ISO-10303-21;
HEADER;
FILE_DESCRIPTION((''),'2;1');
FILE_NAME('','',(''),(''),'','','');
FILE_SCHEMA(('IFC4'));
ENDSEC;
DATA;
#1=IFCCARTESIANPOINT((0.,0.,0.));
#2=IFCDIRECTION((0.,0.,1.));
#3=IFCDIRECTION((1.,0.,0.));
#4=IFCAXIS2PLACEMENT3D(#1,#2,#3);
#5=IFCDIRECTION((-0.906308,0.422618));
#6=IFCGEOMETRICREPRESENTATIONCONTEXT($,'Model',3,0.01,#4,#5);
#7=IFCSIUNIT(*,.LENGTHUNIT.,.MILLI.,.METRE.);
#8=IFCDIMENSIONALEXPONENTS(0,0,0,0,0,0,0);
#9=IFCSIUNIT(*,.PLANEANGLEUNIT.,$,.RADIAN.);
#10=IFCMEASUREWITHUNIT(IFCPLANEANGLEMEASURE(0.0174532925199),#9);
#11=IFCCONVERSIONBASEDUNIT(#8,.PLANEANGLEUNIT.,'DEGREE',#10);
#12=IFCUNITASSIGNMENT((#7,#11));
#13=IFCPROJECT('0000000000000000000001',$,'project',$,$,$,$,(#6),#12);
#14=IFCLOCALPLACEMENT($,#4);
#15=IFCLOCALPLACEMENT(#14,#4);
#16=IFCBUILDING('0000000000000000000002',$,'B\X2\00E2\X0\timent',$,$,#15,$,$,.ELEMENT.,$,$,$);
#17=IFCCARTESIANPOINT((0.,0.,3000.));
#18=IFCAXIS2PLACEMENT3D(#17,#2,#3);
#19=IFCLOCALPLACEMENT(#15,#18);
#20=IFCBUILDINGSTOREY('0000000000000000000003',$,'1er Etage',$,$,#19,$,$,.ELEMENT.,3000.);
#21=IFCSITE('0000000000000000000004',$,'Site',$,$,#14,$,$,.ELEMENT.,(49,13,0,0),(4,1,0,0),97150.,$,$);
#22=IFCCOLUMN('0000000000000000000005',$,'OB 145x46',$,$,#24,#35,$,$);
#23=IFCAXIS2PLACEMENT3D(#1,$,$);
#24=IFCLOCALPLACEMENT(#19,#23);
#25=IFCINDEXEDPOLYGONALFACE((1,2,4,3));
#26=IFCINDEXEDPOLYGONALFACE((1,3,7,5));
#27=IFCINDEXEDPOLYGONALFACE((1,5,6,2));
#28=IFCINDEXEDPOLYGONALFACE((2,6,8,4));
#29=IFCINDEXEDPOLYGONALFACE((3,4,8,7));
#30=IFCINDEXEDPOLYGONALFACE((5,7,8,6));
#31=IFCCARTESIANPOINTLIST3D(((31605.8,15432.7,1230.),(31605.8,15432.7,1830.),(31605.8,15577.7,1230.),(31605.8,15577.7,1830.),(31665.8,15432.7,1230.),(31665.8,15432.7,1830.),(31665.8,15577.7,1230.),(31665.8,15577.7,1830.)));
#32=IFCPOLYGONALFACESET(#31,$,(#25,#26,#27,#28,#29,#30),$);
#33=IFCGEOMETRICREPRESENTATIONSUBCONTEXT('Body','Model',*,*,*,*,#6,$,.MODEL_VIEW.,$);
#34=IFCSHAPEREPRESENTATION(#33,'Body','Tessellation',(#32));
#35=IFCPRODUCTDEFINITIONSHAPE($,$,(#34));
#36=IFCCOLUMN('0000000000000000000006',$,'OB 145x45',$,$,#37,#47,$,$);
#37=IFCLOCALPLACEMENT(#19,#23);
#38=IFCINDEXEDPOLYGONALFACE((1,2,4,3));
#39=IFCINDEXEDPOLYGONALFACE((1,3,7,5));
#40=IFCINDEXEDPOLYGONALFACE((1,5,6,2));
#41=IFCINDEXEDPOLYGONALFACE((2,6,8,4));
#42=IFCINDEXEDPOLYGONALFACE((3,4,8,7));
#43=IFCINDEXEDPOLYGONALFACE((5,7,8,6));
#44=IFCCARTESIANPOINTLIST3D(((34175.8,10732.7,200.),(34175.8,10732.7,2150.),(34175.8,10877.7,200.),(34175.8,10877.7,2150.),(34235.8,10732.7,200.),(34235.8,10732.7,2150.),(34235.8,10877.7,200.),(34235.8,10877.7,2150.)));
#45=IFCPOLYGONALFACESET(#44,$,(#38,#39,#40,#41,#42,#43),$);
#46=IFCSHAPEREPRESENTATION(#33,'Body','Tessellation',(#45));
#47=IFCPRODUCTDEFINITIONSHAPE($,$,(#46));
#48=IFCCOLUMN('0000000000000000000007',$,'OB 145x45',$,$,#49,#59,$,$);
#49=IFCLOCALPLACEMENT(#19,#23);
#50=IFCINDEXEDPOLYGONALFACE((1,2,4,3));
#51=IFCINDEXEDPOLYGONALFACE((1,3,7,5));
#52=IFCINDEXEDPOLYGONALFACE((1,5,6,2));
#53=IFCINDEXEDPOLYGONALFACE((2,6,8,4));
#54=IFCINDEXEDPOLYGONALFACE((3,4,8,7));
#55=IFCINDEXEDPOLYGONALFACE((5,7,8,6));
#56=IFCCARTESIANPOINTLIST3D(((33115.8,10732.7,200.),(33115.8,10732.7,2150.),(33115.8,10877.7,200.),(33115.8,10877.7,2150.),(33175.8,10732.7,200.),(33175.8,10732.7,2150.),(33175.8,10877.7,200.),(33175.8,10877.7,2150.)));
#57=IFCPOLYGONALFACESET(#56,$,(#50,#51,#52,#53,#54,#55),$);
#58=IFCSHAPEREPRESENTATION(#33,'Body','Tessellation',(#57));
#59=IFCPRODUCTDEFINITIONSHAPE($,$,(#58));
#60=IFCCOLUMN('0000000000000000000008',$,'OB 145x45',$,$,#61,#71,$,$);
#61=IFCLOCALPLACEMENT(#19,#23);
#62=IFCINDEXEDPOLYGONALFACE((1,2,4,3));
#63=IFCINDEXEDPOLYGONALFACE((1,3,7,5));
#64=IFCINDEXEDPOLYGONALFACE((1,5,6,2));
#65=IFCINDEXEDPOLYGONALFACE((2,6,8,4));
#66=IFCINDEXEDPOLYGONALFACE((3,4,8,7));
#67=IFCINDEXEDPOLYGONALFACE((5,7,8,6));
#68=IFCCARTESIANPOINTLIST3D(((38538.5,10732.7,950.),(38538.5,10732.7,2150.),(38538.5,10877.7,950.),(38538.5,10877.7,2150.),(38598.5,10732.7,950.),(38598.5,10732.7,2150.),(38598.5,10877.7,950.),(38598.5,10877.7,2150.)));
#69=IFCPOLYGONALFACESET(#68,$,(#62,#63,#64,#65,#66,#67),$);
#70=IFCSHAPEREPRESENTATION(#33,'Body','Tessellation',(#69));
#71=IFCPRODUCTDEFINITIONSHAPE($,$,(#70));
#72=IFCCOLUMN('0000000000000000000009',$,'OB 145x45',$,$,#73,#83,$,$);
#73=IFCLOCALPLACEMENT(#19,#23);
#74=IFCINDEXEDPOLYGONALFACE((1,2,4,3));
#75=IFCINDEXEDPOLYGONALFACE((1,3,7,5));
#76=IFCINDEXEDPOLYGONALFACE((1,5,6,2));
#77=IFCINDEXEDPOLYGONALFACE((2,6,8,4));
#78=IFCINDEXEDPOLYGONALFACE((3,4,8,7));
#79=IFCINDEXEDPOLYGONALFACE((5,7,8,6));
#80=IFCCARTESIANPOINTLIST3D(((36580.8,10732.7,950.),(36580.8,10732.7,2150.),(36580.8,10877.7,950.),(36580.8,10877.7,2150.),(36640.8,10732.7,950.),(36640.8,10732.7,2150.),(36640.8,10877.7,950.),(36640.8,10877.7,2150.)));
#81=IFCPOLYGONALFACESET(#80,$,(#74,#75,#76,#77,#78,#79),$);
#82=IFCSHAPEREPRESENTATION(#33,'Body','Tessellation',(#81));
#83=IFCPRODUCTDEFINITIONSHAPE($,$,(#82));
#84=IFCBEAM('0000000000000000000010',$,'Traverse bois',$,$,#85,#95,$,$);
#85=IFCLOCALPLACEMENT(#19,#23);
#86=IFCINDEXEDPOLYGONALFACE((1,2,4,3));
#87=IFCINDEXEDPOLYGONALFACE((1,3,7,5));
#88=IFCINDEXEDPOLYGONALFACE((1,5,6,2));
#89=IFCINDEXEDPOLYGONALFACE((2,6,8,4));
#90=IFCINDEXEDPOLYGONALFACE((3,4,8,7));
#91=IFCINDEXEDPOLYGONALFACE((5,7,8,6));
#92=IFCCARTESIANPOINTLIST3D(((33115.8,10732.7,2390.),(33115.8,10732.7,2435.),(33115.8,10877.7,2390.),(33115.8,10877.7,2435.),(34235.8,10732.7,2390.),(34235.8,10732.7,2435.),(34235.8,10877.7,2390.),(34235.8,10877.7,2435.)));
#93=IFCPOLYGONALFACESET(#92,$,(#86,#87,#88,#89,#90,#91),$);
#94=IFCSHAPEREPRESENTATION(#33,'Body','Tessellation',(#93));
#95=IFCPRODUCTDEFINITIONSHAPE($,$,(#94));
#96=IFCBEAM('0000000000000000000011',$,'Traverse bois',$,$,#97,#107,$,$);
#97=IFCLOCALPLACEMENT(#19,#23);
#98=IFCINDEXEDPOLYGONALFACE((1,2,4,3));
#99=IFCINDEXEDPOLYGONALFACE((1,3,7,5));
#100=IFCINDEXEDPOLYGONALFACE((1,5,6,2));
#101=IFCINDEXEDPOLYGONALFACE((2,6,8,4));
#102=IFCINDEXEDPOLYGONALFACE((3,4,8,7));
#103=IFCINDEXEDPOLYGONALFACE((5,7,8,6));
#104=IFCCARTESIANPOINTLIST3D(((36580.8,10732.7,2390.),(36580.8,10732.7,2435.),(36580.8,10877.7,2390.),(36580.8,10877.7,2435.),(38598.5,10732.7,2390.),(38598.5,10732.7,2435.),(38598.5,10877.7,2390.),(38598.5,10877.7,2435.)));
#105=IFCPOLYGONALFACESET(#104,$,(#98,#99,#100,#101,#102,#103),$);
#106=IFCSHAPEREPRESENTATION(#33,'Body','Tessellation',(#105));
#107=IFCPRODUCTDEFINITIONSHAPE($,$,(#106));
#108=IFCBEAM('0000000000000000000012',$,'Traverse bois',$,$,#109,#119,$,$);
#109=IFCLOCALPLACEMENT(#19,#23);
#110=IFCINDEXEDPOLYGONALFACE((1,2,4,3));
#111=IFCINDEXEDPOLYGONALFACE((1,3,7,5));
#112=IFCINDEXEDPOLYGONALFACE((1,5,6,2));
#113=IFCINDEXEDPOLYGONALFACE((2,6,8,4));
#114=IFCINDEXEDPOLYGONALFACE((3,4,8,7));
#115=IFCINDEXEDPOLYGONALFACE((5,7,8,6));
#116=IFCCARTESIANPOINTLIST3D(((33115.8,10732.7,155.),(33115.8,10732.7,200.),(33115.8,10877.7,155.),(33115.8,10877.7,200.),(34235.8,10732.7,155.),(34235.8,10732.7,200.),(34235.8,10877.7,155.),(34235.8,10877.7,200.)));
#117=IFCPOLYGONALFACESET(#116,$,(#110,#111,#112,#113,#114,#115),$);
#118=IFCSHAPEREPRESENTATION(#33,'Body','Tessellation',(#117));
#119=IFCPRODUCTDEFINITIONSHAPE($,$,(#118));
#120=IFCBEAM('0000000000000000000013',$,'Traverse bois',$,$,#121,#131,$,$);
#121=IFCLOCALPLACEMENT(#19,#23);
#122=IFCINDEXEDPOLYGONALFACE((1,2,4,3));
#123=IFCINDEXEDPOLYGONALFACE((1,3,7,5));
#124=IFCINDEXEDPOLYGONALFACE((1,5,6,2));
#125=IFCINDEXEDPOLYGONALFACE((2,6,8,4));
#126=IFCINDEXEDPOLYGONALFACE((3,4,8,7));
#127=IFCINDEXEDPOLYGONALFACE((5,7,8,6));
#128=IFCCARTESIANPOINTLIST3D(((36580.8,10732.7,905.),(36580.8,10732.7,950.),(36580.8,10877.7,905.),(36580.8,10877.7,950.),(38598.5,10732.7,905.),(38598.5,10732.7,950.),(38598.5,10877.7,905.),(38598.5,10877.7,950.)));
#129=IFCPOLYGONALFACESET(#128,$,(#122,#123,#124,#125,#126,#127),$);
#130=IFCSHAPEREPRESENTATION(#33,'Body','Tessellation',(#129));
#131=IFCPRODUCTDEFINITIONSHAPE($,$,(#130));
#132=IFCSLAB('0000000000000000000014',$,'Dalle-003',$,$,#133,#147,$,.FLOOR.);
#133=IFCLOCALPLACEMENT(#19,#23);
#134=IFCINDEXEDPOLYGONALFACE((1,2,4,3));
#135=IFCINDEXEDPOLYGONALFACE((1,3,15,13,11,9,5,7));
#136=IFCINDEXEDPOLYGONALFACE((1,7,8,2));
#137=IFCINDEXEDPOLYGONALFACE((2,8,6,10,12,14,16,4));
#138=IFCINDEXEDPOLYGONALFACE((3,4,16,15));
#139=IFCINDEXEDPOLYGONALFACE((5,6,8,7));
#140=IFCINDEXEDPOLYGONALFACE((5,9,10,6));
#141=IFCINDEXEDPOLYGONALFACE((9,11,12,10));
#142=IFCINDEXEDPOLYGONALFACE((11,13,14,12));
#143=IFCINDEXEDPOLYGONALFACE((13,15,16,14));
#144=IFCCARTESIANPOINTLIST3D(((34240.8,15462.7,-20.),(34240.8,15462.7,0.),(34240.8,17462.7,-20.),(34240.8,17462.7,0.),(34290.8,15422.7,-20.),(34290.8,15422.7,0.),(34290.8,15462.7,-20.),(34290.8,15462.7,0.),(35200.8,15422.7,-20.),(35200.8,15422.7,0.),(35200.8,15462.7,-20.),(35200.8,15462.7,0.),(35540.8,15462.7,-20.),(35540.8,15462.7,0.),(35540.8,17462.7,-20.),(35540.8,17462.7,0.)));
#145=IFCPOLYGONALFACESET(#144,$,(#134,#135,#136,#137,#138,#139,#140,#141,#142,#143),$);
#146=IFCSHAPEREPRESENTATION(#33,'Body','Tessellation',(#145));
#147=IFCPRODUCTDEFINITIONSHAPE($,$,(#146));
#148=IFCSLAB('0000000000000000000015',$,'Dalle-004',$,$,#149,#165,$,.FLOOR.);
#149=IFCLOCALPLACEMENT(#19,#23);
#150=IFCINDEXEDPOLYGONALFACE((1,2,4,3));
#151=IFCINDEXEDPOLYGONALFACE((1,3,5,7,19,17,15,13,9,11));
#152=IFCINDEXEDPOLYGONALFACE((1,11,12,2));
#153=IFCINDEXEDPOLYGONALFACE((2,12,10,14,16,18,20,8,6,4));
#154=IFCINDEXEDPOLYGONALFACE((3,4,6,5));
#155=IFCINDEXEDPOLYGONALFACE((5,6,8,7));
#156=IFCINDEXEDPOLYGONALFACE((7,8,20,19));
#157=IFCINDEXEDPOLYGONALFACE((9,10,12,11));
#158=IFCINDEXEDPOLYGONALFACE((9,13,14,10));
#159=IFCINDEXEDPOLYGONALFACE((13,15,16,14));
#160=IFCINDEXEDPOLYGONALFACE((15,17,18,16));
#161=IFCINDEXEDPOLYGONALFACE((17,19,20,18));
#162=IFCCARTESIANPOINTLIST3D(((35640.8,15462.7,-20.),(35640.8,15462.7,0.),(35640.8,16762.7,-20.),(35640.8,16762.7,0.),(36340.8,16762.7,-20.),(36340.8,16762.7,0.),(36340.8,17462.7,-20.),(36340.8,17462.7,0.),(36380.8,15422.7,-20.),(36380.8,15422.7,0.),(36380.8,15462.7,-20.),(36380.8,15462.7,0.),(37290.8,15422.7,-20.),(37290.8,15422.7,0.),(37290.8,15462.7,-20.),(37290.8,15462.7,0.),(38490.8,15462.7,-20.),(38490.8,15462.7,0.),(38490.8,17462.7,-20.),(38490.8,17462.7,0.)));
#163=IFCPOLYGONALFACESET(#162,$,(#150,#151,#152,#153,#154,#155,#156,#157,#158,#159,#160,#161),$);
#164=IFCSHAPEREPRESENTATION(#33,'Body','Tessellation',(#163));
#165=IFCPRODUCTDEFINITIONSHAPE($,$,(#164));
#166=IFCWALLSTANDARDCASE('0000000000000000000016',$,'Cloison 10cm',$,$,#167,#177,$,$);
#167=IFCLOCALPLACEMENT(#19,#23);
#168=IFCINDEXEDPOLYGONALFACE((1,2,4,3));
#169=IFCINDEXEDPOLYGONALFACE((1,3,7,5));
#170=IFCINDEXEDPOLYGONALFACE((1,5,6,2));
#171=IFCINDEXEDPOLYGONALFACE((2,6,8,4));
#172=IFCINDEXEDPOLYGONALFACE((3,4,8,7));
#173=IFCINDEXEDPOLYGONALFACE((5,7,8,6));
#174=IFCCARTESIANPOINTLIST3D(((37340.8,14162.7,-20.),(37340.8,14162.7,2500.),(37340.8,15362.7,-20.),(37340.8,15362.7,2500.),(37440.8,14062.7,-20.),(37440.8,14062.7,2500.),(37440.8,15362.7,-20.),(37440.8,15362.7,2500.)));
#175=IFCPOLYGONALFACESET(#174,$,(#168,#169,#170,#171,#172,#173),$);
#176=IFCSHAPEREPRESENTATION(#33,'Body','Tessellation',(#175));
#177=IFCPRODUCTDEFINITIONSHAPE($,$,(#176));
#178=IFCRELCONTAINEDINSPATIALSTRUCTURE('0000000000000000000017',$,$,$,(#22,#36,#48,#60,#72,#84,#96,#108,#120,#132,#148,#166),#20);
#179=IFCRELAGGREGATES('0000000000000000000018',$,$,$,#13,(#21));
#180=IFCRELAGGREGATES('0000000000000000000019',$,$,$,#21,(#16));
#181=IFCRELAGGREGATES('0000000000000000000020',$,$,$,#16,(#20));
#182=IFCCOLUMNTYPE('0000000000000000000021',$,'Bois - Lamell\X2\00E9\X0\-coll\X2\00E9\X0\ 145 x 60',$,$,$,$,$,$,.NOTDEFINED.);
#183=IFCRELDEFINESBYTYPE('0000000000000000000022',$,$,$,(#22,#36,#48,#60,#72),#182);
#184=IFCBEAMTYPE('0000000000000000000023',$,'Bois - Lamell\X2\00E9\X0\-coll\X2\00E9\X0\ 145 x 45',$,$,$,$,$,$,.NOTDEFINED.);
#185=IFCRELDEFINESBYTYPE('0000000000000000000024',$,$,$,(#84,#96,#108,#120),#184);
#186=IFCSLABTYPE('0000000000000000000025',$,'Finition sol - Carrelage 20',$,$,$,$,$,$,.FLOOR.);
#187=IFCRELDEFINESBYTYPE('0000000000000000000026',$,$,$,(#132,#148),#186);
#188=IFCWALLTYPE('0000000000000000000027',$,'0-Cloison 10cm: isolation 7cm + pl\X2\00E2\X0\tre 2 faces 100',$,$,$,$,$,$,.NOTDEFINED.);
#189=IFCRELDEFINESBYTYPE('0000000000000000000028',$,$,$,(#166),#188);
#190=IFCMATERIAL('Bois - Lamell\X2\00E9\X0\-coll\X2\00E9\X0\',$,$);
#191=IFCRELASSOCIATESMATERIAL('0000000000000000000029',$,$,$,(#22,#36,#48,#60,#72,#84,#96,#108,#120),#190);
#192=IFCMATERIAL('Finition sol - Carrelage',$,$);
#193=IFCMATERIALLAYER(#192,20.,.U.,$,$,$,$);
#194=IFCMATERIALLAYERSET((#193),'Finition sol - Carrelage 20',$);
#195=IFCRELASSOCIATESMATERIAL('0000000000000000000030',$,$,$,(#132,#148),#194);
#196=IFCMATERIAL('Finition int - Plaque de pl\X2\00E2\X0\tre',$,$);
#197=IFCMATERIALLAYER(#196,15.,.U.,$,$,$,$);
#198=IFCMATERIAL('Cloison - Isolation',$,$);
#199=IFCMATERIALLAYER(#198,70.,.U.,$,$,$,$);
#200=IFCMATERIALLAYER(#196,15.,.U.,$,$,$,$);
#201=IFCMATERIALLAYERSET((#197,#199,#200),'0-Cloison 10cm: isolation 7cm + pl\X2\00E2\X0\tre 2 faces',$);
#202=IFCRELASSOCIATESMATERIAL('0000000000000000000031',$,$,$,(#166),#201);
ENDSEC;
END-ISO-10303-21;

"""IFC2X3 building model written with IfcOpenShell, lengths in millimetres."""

from ifc_helpers import new_model, entity, si_unit, converted_unit, direction, frame, frame_2d, origin_with_axes, origin_2d_with_axis, place, context, subcontext, project, spatial, polyline, rectangle, outline, extrude, material, layer, layer_set, layer_usage, type_object, element, save


model = new_model("IFC2X3")

# Units and contexts
model_context = context("Model", 3, precision=0.01, world=origin_with_axes(), true_north=direction((-0.906308, 0.422618)))
body_context = subcontext(model_context, "Body", "Model", "MODEL_VIEW")
ifc_project = project(units=[si_unit("LENGTHUNIT", "METRE", prefix="MILLI"), converted_unit("PLANEANGLEUNIT", "DEGREE", entity("IfcPlaneAngleMeasure", 0.0174532925199), si_unit("PLANEANGLEUNIT", "RADIAN"), dimensions=[0, 0, 0, 0, 0, 0, 0])], contexts=[model_context])

# Site, building, storey
site_placement = place(None, origin_with_axes())
site = spatial("IfcSite", under=ifc_project, at=site_placement, Name="Site", CompositionType="ELEMENT", RefLatitude=(49, 13, 0, 0), RefLongitude=(4, 1, 0, 0), RefElevation=97150.0)
building_placement = place(site_placement, origin_with_axes())
building = spatial("IfcBuilding", under=site, at=building_placement, Name="Bâtiment", CompositionType="ELEMENT")
storey_placement = place(building_placement, frame((0.0, 0.0, 3000.0), z_axis=(0.0, 0.0, 1.0), x_axis=(1.0, 0.0, 0.0)))
storey = spatial("IfcBuildingStorey", under=building, at=storey_placement, Name="1er Etage", CompositionType="ELEMENT", Elevation=3000.0)

# Columns
ifc_material_1 = material(Name="Bois - Lamellé-collé")
column_type = type_object("IfcColumnType", Name="Bois - Lamellé-collé 145 x 60", PredefinedType="NOTDEFINED")
column_placement = place(storey_placement, frame((31635.8, 15505.2, 1230.0), z_axis=(0.0, 0.0, 1.0), x_axis=(0.0, -1.0, 0.0)))
element("IfcColumn", 1, at=column_placement, inside=storey, type_object=column_type, material=ifc_material_1, Name="OB 145x46", context=body_context, shape_type="SweptSolid", body=[
    extrude(rectangle(XDim=145.0, YDim=60.0, at=origin_2d_with_axis()), origin_with_axes(), (0.0, 0.0, 1.0), 600.0),
])
for number, where, z_axis, x_axis, name in (
    (2, (34205.8, 10805.2, 200.0), (0.0, 0.0, 1.0), (0.0, 1.0, 0.0), "OB 145x45"),
    (3, (33145.8, 10805.2, 200.0), (0.0, 0.0, 1.0), (0.0, 1.0, 0.0), "OB 145x45"),
):
    element("IfcColumn", number, at=place(storey_placement, frame(where, z_axis=z_axis, x_axis=x_axis)), inside=storey, type_object=column_type, material=ifc_material_1, Name=name, context=body_context, shape_type="SweptSolid", body=[
        extrude(rectangle(XDim=145.0, YDim=60.0, at=origin_2d_with_axis()), frame((0.0, 0.0, 0.0), z_axis=(0.0, 0.0, -1.0), x_axis=(-1.0, 0.0, 0.0)), (0.0, 0.0, -1.0), 1950.0),
    ])
for number, where, z_axis, x_axis, name in (
    (4, (38568.5, 10805.2, 950.0), (0.0, 0.0, 1.0), (0.0, 1.0, 0.0), "OB 145x45"),
    (5, (36610.8, 10805.2, 950.0), (0.0, 0.0, 1.0), (0.0, 1.0, 0.0), "OB 145x45"),
):
    element("IfcColumn", number, at=place(storey_placement, frame(where, z_axis=z_axis, x_axis=x_axis)), inside=storey, type_object=column_type, material=ifc_material_1, Name=name, context=body_context, shape_type="SweptSolid", body=[
        extrude(rectangle(XDim=145.0, YDim=60.0, at=origin_2d_with_axis()), frame((0.0, 0.0, 0.0), z_axis=(0.0, 0.0, -1.0), x_axis=(-1.0, 0.0, 0.0)), (0.0, 0.0, -1.0), 1200.0),
    ])

# Beams
beam_type = type_object("IfcBeamType", Name="Bois - Lamellé-collé 145 x 45", PredefinedType="NOTDEFINED")
beam_1_placement = place(storey_placement, frame((33115.8, 10805.2, 2435.0), z_axis=(0.0, 0.0, 1.0), x_axis=(0.0, -1.0, 0.0)))
element("IfcBeam", 6, at=beam_1_placement, inside=storey, type_object=beam_type, material=ifc_material_1, Name="Traverse bois", context=body_context, shape_type="SweptSolid", body=[
    extrude(rectangle(XDim=45.0, YDim=145.0, at=frame_2d((-22.5, 0.0), x_axis=(1.0, 0.0))), frame((0.0, 0.0, 0.0), z_axis=(0.0, 1.0, 0.0), x_axis=(0.0, 0.0, 1.0)), (0.0, 0.0, 1.0), 1120.0),
])
beam_2_placement = place(storey_placement, frame((36580.8, 10805.2, 2435.0), z_axis=(0.0, 0.0, 1.0), x_axis=(0.0, -1.0, 0.0)))
element("IfcBeam", 7, at=beam_2_placement, inside=storey, type_object=beam_type, material=ifc_material_1, Name="Traverse bois", context=body_context, shape_type="SweptSolid", body=[
    extrude(rectangle(XDim=45.0, YDim=145.0, at=frame_2d((-22.5, 0.0), x_axis=(1.0, 0.0))), frame((0.0, 0.0, 0.0), z_axis=(0.0, 1.0, 0.0), x_axis=(0.0, 0.0, 1.0)), (0.0, 0.0, 1.0), 2017.7),
])
beam_3_placement = place(storey_placement, frame((33115.8, 10805.2, 200.0), z_axis=(0.0, 0.0, 1.0), x_axis=(0.0, -1.0, 0.0)))
element("IfcBeam", 8, at=beam_3_placement, inside=storey, type_object=beam_type, material=ifc_material_1, Name="Traverse bois", context=body_context, shape_type="SweptSolid", body=[
    extrude(rectangle(XDim=45.0, YDim=145.0, at=frame_2d((-22.5, 0.0), x_axis=(1.0, 0.0))), frame((0.0, 0.0, 0.0), z_axis=(0.0, 1.0, 0.0), x_axis=(0.0, 0.0, 1.0)), (0.0, 0.0, 1.0), 1120.0),
])
beam_4_placement = place(storey_placement, frame((36580.8, 10805.2, 950.0), z_axis=(0.0, 0.0, 1.0), x_axis=(0.0, -1.0, 0.0)))
element("IfcBeam", 9, at=beam_4_placement, inside=storey, type_object=beam_type, material=ifc_material_1, Name="Traverse bois", context=body_context, shape_type="SweptSolid", body=[
    extrude(rectangle(XDim=45.0, YDim=145.0, at=frame_2d((-22.5, 0.0), x_axis=(1.0, 0.0))), frame((0.0, 0.0, 0.0), z_axis=(0.0, 1.0, 0.0), x_axis=(0.0, 0.0, 1.0)), (0.0, 0.0, 1.0), 2017.7),
])

# Slabs
ifc_material_2 = material(Name="Finition sol - Carrelage")
ifc_layer_1 = layer(ifc_material_2, 20.0, ventilated="UNKNOWN")
ifc_layer_set_1 = layer_set([ifc_layer_1], Name="Finition sol - Carrelage 20")
ifc_layer_usage_1 = layer_usage(ifc_layer_set_1, "AXIS3", "NEGATIVE", 20.0)
slab_type_1 = type_object("IfcSlabType", Name="Finition sol - Carrelage 20", PredefinedType="FLOOR")
slab_1_placement = place(storey_placement, frame((34240.8, 15462.7, 0.0), z_axis=(0.0, 0.0, 1.0), x_axis=(1.0, 0.0, 0.0)))
element("IfcSlab", 10, at=slab_1_placement, inside=storey, type_object=slab_type_1, material=ifc_layer_usage_1, Name="Dalle-003", PredefinedType="FLOOR", context=body_context, shape_type="SweptSolid", body=[
    extrude(outline(polyline([(0.0, 0.0), (50.0, 0.0), (50.0, -40.0), (960.0, -40.0), (960.0, 0.0), (1300.0, 0.0), (1300.0, 2000.0), (0.0, 2000.0), (0.0, 0.0)])), frame((0.0, 0.0, -20.0), z_axis=(0.0, 0.0, 1.0), x_axis=(1.0, 0.0, 0.0)), (0.0, 0.0, 1.0), 20.0),
])
ifc_layer_usage_2 = layer_usage(ifc_layer_set_1, "AXIS3", "NEGATIVE", 20.0)
slab_2_placement = place(storey_placement, frame((35640.8, 15462.7, 0.0), z_axis=(0.0, 0.0, 1.0), x_axis=(1.0, 0.0, 0.0)))
element("IfcSlab", 11, at=slab_2_placement, inside=storey, type_object=slab_type_1, material=ifc_layer_usage_2, Name="Dalle-004", PredefinedType="FLOOR", context=body_context, shape_type="SweptSolid", body=[
    extrude(outline(polyline([(0.0, 0.0), (740.0, 0.0), (740.0, -40.0), (1650.0, -40.0), (1650.0, 0.0), (2850.0, 0.0), (2850.0, 2000.0), (700.0, 2000.0), (700.0, 1300.0), (0.0, 1300.0), (0.0, 0.0)])), frame((0.0, 0.0, -20.0), z_axis=(0.0, 0.0, 1.0), x_axis=(1.0, 0.0, 0.0)), (0.0, 0.0, 1.0), 20.0),
])
ifc_material_3 = material(Name="Finition int - Plaque de plâtre")

# Wall
ifc_layer_2 = layer(ifc_material_3, 15.0, ventilated="UNKNOWN")
ifc_material_4 = material(Name="Cloison - Isolation")
ifc_layer_3 = layer(ifc_material_4, 70.0, ventilated="UNKNOWN")
ifc_layer_4 = layer(ifc_material_3, 15.0, ventilated="UNKNOWN")
ifc_layer_set_2 = layer_set([ifc_layer_2, ifc_layer_3, ifc_layer_4], Name="0-Cloison 10cm: isolation 7cm + plâtre 2 faces")
ifc_layer_usage_3 = layer_usage(ifc_layer_set_2, "AXIS2", "POSITIVE", -50.0)
wall_type_1 = type_object("IfcWallType", Name="0-Cloison 10cm: isolation 7cm + plâtre 2 faces 100", PredefinedType="NOTDEFINED")
wall_1_placement = place(storey_placement, frame((37390.8, 14112.7, -20.0), z_axis=(0.0, 0.0, 1.0), x_axis=(0.0, 1.0, 0.0)))
element("IfcWallStandardCase", 12, at=wall_1_placement, inside=storey, type_object=wall_type_1, material=ifc_layer_usage_3, Name="Cloison 10cm", context=body_context, shape_type="SweptSolid", body=[
    extrude(outline(polyline([(-50.0, -50.0), (1250.0, -50.0), (1250.0, 50.0), (50.0, 50.0), (-50.0, -50.0)])), origin_with_axes(), (0.0, 0.0, 1.0), 2520.0),
])

save(model, "model.ifc")
